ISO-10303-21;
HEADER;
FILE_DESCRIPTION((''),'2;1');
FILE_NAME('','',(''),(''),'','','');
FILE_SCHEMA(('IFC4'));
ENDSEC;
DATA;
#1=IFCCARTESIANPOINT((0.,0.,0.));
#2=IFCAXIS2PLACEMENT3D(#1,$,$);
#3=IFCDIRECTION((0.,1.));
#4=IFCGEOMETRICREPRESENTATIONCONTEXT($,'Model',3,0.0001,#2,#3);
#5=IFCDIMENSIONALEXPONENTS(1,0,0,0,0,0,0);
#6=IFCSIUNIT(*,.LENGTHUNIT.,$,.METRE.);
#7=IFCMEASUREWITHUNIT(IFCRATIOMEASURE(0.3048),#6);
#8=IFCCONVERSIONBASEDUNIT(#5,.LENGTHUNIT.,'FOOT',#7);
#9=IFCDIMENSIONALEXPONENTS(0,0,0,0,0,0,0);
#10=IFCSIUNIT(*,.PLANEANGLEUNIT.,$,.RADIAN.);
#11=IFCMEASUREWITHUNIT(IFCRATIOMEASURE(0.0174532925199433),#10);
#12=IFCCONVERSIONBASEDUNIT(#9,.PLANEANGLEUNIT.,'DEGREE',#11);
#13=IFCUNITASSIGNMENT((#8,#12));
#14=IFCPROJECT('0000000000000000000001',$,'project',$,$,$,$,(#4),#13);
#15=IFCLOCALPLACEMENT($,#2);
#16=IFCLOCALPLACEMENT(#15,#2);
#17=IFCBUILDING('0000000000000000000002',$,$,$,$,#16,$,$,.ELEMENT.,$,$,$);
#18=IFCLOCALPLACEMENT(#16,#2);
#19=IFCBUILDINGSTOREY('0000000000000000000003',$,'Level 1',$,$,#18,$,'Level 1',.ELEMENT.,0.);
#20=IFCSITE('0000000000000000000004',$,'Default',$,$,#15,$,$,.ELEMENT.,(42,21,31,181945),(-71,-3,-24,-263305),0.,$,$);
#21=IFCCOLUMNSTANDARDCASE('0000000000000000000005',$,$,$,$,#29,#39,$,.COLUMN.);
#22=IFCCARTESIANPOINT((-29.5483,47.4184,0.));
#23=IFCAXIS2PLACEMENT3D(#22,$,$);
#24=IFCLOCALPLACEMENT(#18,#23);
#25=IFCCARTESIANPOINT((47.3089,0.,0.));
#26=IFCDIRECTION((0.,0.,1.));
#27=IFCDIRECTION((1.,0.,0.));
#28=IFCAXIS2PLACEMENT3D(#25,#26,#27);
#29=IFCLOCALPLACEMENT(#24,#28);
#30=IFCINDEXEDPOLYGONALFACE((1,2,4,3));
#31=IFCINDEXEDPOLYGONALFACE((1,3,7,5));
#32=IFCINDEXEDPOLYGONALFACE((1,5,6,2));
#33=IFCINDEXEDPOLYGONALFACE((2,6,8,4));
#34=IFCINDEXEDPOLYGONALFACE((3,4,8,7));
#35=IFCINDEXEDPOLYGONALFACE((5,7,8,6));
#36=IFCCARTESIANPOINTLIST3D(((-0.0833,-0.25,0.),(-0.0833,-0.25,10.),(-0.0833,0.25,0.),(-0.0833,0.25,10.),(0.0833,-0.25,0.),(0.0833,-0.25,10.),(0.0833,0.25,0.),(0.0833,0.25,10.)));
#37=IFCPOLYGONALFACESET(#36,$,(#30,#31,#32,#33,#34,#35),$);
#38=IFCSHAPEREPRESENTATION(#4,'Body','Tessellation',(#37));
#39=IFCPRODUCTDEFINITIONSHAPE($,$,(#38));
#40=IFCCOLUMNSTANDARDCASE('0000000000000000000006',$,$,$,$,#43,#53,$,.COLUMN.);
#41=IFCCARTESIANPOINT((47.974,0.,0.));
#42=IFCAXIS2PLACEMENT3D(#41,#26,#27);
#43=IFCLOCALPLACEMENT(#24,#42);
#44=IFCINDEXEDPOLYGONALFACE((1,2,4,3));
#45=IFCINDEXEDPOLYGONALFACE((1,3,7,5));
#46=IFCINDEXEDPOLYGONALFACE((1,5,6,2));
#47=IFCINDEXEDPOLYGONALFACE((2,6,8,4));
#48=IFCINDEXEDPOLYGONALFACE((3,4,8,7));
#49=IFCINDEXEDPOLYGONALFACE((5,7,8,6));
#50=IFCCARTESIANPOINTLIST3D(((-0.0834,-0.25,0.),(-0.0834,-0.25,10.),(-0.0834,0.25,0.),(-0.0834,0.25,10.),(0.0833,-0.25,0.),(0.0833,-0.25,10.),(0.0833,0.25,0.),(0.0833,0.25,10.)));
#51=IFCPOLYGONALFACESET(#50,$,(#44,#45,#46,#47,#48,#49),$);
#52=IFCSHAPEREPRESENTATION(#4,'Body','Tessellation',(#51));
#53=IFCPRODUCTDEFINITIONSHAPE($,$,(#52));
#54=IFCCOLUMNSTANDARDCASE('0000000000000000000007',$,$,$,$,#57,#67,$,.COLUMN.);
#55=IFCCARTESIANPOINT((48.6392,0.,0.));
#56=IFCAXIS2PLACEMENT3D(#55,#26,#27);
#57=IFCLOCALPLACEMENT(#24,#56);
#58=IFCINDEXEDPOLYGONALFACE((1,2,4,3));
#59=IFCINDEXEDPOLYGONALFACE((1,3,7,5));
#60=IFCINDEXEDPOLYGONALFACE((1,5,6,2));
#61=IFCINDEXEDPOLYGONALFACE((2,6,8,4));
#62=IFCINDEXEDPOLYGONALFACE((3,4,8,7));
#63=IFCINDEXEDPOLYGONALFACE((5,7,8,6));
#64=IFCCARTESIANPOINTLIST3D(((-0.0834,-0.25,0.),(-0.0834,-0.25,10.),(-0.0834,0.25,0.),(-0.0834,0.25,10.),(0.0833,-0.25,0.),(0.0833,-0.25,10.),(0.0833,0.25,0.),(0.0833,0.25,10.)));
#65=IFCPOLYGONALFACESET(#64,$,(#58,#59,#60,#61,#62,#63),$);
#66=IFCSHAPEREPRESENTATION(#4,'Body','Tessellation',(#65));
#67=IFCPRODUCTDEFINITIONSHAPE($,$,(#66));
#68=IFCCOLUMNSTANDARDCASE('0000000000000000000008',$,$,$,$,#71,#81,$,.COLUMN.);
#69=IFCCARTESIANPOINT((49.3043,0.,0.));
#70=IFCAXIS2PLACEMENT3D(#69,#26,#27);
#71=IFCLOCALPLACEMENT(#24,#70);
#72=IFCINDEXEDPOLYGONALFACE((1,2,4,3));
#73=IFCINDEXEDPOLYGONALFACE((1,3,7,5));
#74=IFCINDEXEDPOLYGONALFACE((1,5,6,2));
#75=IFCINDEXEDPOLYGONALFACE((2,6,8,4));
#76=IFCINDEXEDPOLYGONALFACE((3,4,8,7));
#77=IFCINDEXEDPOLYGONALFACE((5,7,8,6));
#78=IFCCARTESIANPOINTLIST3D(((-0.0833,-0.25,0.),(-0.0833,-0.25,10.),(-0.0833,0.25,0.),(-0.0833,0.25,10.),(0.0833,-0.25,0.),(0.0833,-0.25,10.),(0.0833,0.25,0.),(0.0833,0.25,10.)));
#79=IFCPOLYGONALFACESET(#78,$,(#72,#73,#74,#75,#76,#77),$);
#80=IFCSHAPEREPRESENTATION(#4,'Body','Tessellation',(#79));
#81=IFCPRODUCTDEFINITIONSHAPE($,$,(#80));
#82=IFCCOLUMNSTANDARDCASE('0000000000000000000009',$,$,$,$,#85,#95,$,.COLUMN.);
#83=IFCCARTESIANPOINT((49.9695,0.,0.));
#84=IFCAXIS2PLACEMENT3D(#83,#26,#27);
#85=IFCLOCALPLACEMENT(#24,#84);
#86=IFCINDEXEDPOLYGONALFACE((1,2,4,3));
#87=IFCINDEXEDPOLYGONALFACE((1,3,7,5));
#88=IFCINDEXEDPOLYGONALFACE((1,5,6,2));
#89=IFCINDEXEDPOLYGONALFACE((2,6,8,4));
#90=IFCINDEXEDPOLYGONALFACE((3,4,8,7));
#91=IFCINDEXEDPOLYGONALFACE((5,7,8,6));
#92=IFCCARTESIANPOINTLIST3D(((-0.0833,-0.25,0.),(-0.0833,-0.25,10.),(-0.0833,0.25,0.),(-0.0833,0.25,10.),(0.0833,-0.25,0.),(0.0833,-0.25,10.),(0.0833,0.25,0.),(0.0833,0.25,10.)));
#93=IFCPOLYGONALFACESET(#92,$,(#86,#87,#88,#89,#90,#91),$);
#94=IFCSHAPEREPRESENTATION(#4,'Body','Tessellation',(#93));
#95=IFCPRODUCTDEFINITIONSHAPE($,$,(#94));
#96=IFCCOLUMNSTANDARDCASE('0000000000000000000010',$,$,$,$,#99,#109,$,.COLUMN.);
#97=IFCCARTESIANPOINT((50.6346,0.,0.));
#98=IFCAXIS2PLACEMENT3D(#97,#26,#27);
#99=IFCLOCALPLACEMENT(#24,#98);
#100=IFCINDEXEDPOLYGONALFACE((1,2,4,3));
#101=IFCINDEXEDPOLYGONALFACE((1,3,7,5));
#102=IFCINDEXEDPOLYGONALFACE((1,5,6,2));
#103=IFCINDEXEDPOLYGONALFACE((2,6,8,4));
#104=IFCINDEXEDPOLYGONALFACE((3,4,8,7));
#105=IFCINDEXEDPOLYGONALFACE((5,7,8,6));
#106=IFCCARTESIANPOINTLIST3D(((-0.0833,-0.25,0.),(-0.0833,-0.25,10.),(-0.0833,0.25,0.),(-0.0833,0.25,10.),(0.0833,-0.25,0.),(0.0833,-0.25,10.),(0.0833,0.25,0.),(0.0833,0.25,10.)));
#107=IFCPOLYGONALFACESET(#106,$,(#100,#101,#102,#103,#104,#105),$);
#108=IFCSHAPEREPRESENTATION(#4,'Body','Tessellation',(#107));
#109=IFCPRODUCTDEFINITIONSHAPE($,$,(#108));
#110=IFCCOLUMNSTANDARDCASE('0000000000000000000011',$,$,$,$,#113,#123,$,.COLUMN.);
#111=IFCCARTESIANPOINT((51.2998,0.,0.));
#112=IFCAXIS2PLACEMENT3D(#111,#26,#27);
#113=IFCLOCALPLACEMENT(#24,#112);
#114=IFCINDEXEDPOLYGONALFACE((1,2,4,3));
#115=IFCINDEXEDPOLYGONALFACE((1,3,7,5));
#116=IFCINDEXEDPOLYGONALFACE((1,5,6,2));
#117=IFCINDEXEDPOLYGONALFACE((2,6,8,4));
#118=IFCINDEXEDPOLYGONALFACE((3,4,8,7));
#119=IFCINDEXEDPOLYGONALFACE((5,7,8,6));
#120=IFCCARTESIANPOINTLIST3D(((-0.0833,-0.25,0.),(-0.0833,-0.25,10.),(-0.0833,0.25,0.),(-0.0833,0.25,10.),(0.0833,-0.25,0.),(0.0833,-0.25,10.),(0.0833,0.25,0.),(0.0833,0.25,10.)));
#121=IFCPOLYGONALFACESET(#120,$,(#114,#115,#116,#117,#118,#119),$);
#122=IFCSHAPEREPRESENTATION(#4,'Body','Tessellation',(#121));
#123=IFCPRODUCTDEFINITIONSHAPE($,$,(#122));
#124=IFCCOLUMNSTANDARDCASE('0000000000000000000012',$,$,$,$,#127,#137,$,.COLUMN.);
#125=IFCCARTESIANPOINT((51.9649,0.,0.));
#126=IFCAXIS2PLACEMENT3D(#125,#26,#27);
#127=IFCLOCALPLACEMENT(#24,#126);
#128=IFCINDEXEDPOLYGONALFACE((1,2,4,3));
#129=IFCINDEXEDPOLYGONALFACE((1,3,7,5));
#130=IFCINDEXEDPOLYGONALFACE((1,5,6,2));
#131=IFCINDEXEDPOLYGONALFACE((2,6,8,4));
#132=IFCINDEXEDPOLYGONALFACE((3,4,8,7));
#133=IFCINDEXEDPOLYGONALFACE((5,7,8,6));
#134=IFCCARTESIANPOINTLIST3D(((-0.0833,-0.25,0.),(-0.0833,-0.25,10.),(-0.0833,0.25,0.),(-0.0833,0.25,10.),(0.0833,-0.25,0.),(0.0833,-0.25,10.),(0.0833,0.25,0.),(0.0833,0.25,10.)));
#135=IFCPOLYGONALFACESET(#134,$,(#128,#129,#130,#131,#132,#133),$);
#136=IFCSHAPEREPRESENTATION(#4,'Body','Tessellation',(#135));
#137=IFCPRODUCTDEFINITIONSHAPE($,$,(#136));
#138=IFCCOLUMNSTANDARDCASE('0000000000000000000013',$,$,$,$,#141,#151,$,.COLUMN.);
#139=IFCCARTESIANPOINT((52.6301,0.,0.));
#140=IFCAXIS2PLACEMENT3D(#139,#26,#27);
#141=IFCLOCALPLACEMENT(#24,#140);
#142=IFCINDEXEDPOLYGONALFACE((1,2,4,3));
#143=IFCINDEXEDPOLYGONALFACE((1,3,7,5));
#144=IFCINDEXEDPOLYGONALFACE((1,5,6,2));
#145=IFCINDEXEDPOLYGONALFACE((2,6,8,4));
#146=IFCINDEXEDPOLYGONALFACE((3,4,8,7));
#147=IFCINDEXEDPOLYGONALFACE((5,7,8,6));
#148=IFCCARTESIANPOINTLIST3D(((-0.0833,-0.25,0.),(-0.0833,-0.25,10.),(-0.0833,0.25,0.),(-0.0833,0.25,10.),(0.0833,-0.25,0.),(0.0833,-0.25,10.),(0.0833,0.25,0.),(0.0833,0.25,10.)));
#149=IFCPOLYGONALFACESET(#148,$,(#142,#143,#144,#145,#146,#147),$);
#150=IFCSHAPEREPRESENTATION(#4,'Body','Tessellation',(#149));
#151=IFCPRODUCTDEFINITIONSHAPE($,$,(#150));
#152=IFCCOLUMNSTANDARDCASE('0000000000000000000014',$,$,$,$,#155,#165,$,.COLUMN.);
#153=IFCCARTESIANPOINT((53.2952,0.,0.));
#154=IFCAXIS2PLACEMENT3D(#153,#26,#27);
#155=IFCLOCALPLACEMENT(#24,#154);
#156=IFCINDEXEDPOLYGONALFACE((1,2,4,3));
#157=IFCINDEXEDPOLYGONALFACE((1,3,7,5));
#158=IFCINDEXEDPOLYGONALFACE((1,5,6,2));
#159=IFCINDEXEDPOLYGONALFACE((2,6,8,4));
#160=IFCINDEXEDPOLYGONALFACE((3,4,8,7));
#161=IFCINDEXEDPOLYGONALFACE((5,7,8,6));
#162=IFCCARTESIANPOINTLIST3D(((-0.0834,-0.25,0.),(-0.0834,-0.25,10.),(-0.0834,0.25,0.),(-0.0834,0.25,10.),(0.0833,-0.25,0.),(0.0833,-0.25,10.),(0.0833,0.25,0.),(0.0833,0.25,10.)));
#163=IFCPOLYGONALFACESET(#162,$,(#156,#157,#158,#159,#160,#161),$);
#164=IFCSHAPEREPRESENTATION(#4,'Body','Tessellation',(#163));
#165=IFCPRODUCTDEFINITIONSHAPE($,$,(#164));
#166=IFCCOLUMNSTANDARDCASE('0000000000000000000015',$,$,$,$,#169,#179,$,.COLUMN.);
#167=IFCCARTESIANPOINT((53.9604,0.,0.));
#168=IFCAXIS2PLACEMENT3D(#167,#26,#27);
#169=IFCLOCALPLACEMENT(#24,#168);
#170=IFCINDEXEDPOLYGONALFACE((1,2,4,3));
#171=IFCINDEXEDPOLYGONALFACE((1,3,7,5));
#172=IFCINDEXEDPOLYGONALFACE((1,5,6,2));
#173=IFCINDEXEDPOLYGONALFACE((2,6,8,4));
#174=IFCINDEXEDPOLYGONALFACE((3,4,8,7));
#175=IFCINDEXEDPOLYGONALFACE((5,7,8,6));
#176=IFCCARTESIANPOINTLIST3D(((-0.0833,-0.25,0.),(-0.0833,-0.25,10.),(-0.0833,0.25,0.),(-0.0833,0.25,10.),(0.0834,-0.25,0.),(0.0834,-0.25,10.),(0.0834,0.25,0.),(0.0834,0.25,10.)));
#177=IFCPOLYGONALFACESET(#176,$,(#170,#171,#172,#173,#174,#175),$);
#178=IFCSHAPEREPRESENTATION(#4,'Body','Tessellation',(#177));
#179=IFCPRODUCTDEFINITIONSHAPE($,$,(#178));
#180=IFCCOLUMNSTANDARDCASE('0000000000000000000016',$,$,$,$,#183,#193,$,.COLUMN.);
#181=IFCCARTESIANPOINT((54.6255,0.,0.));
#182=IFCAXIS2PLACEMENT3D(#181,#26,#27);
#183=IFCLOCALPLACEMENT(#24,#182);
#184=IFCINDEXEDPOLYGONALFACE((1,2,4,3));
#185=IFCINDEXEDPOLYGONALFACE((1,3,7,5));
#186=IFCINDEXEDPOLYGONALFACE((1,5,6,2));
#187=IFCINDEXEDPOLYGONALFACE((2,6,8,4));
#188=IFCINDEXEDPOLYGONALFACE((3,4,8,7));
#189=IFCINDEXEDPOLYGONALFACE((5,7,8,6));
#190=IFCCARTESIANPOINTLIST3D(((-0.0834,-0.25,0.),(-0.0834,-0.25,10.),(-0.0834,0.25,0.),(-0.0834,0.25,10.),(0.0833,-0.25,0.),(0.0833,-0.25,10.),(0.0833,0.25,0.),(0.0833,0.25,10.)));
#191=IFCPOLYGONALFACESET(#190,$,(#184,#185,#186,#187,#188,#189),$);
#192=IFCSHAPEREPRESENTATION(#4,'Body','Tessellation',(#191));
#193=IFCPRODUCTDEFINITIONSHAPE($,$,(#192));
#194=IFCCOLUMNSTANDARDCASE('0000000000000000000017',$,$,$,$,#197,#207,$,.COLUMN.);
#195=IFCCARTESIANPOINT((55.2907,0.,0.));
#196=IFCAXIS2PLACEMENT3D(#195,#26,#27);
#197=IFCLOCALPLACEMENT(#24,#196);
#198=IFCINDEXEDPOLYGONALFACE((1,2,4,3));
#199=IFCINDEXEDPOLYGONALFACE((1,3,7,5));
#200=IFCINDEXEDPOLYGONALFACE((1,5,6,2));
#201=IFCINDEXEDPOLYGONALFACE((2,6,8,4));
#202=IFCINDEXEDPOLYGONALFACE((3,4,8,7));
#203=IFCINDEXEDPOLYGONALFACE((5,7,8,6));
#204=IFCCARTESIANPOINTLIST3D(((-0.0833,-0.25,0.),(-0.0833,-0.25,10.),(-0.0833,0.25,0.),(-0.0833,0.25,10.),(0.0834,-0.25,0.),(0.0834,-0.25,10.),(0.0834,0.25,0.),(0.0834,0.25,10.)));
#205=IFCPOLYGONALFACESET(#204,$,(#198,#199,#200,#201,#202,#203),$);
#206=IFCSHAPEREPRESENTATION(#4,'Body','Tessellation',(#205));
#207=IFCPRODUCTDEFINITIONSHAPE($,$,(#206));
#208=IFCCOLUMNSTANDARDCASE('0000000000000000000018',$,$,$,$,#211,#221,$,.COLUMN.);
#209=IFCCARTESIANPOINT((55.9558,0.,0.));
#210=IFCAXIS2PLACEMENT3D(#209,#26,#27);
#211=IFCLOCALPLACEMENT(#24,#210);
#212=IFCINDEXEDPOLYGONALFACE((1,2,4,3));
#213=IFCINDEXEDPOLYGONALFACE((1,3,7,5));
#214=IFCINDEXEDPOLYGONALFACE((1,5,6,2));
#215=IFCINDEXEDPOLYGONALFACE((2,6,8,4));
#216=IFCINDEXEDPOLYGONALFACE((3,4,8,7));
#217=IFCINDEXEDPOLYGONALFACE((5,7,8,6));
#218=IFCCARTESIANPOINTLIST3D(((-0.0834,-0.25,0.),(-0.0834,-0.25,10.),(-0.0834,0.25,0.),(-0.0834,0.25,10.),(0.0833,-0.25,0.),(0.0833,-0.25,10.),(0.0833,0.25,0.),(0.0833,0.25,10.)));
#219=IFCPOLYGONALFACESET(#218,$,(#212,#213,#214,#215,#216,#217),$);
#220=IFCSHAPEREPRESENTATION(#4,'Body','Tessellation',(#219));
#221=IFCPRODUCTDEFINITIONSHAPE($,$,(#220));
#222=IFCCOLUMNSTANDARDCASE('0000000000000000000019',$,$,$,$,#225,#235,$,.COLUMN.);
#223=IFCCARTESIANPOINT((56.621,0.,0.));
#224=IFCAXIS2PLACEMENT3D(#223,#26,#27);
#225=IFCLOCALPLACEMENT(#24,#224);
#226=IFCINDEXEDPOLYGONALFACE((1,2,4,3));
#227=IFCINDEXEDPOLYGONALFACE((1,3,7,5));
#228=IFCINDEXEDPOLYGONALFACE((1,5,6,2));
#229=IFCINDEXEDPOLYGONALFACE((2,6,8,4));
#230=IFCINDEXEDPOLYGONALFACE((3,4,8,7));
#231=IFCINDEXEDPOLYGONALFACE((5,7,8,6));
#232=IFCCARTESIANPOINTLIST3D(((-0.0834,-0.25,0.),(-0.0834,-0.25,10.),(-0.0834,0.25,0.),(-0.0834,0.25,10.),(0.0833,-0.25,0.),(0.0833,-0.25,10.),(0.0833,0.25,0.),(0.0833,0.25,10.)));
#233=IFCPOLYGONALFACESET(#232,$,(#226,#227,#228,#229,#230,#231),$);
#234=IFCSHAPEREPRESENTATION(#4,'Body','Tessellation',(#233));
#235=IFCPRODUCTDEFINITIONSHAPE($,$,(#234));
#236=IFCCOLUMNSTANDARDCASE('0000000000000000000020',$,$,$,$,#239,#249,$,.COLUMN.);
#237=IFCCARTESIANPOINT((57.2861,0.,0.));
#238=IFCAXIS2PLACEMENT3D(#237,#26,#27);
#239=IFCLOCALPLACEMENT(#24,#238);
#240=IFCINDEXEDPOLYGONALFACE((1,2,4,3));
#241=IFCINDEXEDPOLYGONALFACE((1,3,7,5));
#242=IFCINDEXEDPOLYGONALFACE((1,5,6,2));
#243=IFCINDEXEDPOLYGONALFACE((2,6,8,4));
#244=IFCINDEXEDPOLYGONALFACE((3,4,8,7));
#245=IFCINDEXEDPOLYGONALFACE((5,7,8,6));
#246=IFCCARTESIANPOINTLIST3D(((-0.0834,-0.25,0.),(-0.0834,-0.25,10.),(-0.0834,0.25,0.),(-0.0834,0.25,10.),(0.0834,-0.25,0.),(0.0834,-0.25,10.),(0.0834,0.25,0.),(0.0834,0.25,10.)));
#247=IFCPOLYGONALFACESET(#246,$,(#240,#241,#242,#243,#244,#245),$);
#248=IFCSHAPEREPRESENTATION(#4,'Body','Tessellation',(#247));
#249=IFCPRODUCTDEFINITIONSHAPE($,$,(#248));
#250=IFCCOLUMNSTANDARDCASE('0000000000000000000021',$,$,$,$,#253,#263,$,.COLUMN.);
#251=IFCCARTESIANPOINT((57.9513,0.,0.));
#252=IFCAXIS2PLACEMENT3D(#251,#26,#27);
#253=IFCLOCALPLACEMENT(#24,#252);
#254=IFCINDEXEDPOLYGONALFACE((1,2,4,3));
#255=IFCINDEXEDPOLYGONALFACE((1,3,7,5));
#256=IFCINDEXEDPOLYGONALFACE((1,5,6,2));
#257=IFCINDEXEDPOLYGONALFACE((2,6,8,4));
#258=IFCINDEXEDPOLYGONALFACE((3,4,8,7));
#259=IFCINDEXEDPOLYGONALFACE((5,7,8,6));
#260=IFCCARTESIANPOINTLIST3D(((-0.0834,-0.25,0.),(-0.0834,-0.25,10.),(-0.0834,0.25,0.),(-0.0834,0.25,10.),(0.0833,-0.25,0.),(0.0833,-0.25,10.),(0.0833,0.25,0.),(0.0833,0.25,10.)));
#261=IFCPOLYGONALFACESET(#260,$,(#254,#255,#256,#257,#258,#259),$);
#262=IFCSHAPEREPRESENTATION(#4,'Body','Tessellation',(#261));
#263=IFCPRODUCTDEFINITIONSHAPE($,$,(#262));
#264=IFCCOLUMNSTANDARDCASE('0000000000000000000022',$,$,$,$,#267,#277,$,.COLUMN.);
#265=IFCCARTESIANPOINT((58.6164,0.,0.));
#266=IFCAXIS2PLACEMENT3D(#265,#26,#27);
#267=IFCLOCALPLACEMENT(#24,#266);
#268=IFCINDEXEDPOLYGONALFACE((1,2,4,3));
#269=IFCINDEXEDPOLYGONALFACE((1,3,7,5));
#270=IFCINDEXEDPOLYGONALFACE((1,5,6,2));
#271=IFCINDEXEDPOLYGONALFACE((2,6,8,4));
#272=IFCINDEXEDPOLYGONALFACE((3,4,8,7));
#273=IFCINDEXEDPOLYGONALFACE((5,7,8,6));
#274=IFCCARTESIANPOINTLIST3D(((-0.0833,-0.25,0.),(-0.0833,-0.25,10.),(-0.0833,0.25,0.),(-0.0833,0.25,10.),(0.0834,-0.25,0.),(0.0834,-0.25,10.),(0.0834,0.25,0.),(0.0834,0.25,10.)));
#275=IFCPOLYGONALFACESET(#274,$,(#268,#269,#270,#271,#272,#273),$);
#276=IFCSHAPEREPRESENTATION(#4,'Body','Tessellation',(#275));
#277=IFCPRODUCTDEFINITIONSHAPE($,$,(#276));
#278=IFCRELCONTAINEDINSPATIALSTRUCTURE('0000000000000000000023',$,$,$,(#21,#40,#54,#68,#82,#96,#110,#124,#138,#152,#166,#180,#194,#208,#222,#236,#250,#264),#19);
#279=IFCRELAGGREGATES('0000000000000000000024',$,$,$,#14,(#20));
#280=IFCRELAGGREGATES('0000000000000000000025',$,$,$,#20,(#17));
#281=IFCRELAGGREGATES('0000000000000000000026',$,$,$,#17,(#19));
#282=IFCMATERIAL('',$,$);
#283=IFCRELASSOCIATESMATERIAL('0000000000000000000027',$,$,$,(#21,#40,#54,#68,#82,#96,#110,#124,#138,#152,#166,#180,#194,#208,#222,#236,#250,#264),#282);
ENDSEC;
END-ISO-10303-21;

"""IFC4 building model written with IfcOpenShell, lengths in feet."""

from ifc_helpers import new_model, entity, si_unit, converted_unit, direction, frame, origin, place, context, project, spatial, rectangle, extrude, material, element, save


model = new_model("IFC4")

# Units and contexts
model_context = context("Model", 3, precision=0.0001, world=origin(), true_north=direction((0.0, 1.0)))
ifc_project = project(units=[converted_unit("LENGTHUNIT", "FOOT", entity("IfcRatioMeasure", 0.3048), si_unit("LENGTHUNIT", "METRE"), dimensions=[1, 0, 0, 0, 0, 0, 0]), converted_unit("PLANEANGLEUNIT", "DEGREE", entity("IfcRatioMeasure", 0.0174532925199433), si_unit("PLANEANGLEUNIT", "RADIAN"), dimensions=[0, 0, 0, 0, 0, 0, 0])], contexts=[model_context])

# Site, building, storey
site_placement = place(None, origin())
site = spatial("IfcSite", under=ifc_project, at=site_placement, Name="Default", CompositionType="ELEMENT", RefLatitude=(42, 21, 31, 181945), RefLongitude=(-71, -3, -24, -263305), RefElevation=0.0)
building_placement = place(site_placement, origin())
building = spatial("IfcBuilding", under=site, at=building_placement, CompositionType="ELEMENT")
storey_placement = place(building_placement, origin())
storey = spatial("IfcBuildingStorey", under=building, at=storey_placement, Name="Level 1", LongName="Level 1", CompositionType="ELEMENT", Elevation=0.0)

# Columns
ifc_material = material(Name="")
placement = place(storey_placement, frame((-29.5483, 47.4184, 0.0)))
for number, where, z_axis, x_axis in (
    (1, (47.3089, 0.0, 0.0), (0.0, 0.0, 1.0), (1.0, 0.0, 0.0)),
    (2, (47.974, 0.0, 0.0), (0.0, 0.0, 1.0), (1.0, 0.0, 0.0)),
    (3, (48.6392, 0.0, 0.0), (0.0, 0.0, 1.0), (1.0, 0.0, 0.0)),
    (4, (49.3043, 0.0, 0.0), (0.0, 0.0, 1.0), (1.0, 0.0, 0.0)),
    (5, (49.9695, 0.0, 0.0), (0.0, 0.0, 1.0), (1.0, 0.0, 0.0)),
    (6, (50.6346, 0.0, 0.0), (0.0, 0.0, 1.0), (1.0, 0.0, 0.0)),
    (7, (51.2998, 0.0, 0.0), (0.0, 0.0, 1.0), (1.0, 0.0, 0.0)),
    (8, (51.9649, 0.0, 0.0), (0.0, 0.0, 1.0), (1.0, 0.0, 0.0)),
    (9, (52.6301, 0.0, 0.0), (0.0, 0.0, 1.0), (1.0, 0.0, 0.0)),
    (10, (53.2952, 0.0, 0.0), (0.0, 0.0, 1.0), (1.0, 0.0, 0.0)),
    (11, (53.9604, 0.0, 0.0), (0.0, 0.0, 1.0), (1.0, 0.0, 0.0)),
    (12, (54.6255, 0.0, 0.0), (0.0, 0.0, 1.0), (1.0, 0.0, 0.0)),
    (13, (55.2907, 0.0, 0.0), (0.0, 0.0, 1.0), (1.0, 0.0, 0.0)),
    (14, (55.9558, 0.0, 0.0), (0.0, 0.0, 1.0), (1.0, 0.0, 0.0)),
    (15, (56.621, 0.0, 0.0), (0.0, 0.0, 1.0), (1.0, 0.0, 0.0)),
    (16, (57.2861, 0.0, 0.0), (0.0, 0.0, 1.0), (1.0, 0.0, 0.0)),
    (17, (57.9513, 0.0, 0.0), (0.0, 0.0, 1.0), (1.0, 0.0, 0.0)),
    (18, (58.6164, 0.0, 0.0), (0.0, 0.0, 1.0), (1.0, 0.0, 0.0)),
):
    element("IfcColumnStandardCase", number, at=place(placement, frame(where, z_axis=z_axis, x_axis=x_axis)), inside=storey, material=ifc_material, PredefinedType="COLUMN", context=model_context, shape_type="SweptSolid", body=[
        extrude(rectangle(XDim=0.1667, YDim=0.5), origin(), (0.0, 0.0, 1.0), 10.0),
    ])

save(model, "model.ifc")
